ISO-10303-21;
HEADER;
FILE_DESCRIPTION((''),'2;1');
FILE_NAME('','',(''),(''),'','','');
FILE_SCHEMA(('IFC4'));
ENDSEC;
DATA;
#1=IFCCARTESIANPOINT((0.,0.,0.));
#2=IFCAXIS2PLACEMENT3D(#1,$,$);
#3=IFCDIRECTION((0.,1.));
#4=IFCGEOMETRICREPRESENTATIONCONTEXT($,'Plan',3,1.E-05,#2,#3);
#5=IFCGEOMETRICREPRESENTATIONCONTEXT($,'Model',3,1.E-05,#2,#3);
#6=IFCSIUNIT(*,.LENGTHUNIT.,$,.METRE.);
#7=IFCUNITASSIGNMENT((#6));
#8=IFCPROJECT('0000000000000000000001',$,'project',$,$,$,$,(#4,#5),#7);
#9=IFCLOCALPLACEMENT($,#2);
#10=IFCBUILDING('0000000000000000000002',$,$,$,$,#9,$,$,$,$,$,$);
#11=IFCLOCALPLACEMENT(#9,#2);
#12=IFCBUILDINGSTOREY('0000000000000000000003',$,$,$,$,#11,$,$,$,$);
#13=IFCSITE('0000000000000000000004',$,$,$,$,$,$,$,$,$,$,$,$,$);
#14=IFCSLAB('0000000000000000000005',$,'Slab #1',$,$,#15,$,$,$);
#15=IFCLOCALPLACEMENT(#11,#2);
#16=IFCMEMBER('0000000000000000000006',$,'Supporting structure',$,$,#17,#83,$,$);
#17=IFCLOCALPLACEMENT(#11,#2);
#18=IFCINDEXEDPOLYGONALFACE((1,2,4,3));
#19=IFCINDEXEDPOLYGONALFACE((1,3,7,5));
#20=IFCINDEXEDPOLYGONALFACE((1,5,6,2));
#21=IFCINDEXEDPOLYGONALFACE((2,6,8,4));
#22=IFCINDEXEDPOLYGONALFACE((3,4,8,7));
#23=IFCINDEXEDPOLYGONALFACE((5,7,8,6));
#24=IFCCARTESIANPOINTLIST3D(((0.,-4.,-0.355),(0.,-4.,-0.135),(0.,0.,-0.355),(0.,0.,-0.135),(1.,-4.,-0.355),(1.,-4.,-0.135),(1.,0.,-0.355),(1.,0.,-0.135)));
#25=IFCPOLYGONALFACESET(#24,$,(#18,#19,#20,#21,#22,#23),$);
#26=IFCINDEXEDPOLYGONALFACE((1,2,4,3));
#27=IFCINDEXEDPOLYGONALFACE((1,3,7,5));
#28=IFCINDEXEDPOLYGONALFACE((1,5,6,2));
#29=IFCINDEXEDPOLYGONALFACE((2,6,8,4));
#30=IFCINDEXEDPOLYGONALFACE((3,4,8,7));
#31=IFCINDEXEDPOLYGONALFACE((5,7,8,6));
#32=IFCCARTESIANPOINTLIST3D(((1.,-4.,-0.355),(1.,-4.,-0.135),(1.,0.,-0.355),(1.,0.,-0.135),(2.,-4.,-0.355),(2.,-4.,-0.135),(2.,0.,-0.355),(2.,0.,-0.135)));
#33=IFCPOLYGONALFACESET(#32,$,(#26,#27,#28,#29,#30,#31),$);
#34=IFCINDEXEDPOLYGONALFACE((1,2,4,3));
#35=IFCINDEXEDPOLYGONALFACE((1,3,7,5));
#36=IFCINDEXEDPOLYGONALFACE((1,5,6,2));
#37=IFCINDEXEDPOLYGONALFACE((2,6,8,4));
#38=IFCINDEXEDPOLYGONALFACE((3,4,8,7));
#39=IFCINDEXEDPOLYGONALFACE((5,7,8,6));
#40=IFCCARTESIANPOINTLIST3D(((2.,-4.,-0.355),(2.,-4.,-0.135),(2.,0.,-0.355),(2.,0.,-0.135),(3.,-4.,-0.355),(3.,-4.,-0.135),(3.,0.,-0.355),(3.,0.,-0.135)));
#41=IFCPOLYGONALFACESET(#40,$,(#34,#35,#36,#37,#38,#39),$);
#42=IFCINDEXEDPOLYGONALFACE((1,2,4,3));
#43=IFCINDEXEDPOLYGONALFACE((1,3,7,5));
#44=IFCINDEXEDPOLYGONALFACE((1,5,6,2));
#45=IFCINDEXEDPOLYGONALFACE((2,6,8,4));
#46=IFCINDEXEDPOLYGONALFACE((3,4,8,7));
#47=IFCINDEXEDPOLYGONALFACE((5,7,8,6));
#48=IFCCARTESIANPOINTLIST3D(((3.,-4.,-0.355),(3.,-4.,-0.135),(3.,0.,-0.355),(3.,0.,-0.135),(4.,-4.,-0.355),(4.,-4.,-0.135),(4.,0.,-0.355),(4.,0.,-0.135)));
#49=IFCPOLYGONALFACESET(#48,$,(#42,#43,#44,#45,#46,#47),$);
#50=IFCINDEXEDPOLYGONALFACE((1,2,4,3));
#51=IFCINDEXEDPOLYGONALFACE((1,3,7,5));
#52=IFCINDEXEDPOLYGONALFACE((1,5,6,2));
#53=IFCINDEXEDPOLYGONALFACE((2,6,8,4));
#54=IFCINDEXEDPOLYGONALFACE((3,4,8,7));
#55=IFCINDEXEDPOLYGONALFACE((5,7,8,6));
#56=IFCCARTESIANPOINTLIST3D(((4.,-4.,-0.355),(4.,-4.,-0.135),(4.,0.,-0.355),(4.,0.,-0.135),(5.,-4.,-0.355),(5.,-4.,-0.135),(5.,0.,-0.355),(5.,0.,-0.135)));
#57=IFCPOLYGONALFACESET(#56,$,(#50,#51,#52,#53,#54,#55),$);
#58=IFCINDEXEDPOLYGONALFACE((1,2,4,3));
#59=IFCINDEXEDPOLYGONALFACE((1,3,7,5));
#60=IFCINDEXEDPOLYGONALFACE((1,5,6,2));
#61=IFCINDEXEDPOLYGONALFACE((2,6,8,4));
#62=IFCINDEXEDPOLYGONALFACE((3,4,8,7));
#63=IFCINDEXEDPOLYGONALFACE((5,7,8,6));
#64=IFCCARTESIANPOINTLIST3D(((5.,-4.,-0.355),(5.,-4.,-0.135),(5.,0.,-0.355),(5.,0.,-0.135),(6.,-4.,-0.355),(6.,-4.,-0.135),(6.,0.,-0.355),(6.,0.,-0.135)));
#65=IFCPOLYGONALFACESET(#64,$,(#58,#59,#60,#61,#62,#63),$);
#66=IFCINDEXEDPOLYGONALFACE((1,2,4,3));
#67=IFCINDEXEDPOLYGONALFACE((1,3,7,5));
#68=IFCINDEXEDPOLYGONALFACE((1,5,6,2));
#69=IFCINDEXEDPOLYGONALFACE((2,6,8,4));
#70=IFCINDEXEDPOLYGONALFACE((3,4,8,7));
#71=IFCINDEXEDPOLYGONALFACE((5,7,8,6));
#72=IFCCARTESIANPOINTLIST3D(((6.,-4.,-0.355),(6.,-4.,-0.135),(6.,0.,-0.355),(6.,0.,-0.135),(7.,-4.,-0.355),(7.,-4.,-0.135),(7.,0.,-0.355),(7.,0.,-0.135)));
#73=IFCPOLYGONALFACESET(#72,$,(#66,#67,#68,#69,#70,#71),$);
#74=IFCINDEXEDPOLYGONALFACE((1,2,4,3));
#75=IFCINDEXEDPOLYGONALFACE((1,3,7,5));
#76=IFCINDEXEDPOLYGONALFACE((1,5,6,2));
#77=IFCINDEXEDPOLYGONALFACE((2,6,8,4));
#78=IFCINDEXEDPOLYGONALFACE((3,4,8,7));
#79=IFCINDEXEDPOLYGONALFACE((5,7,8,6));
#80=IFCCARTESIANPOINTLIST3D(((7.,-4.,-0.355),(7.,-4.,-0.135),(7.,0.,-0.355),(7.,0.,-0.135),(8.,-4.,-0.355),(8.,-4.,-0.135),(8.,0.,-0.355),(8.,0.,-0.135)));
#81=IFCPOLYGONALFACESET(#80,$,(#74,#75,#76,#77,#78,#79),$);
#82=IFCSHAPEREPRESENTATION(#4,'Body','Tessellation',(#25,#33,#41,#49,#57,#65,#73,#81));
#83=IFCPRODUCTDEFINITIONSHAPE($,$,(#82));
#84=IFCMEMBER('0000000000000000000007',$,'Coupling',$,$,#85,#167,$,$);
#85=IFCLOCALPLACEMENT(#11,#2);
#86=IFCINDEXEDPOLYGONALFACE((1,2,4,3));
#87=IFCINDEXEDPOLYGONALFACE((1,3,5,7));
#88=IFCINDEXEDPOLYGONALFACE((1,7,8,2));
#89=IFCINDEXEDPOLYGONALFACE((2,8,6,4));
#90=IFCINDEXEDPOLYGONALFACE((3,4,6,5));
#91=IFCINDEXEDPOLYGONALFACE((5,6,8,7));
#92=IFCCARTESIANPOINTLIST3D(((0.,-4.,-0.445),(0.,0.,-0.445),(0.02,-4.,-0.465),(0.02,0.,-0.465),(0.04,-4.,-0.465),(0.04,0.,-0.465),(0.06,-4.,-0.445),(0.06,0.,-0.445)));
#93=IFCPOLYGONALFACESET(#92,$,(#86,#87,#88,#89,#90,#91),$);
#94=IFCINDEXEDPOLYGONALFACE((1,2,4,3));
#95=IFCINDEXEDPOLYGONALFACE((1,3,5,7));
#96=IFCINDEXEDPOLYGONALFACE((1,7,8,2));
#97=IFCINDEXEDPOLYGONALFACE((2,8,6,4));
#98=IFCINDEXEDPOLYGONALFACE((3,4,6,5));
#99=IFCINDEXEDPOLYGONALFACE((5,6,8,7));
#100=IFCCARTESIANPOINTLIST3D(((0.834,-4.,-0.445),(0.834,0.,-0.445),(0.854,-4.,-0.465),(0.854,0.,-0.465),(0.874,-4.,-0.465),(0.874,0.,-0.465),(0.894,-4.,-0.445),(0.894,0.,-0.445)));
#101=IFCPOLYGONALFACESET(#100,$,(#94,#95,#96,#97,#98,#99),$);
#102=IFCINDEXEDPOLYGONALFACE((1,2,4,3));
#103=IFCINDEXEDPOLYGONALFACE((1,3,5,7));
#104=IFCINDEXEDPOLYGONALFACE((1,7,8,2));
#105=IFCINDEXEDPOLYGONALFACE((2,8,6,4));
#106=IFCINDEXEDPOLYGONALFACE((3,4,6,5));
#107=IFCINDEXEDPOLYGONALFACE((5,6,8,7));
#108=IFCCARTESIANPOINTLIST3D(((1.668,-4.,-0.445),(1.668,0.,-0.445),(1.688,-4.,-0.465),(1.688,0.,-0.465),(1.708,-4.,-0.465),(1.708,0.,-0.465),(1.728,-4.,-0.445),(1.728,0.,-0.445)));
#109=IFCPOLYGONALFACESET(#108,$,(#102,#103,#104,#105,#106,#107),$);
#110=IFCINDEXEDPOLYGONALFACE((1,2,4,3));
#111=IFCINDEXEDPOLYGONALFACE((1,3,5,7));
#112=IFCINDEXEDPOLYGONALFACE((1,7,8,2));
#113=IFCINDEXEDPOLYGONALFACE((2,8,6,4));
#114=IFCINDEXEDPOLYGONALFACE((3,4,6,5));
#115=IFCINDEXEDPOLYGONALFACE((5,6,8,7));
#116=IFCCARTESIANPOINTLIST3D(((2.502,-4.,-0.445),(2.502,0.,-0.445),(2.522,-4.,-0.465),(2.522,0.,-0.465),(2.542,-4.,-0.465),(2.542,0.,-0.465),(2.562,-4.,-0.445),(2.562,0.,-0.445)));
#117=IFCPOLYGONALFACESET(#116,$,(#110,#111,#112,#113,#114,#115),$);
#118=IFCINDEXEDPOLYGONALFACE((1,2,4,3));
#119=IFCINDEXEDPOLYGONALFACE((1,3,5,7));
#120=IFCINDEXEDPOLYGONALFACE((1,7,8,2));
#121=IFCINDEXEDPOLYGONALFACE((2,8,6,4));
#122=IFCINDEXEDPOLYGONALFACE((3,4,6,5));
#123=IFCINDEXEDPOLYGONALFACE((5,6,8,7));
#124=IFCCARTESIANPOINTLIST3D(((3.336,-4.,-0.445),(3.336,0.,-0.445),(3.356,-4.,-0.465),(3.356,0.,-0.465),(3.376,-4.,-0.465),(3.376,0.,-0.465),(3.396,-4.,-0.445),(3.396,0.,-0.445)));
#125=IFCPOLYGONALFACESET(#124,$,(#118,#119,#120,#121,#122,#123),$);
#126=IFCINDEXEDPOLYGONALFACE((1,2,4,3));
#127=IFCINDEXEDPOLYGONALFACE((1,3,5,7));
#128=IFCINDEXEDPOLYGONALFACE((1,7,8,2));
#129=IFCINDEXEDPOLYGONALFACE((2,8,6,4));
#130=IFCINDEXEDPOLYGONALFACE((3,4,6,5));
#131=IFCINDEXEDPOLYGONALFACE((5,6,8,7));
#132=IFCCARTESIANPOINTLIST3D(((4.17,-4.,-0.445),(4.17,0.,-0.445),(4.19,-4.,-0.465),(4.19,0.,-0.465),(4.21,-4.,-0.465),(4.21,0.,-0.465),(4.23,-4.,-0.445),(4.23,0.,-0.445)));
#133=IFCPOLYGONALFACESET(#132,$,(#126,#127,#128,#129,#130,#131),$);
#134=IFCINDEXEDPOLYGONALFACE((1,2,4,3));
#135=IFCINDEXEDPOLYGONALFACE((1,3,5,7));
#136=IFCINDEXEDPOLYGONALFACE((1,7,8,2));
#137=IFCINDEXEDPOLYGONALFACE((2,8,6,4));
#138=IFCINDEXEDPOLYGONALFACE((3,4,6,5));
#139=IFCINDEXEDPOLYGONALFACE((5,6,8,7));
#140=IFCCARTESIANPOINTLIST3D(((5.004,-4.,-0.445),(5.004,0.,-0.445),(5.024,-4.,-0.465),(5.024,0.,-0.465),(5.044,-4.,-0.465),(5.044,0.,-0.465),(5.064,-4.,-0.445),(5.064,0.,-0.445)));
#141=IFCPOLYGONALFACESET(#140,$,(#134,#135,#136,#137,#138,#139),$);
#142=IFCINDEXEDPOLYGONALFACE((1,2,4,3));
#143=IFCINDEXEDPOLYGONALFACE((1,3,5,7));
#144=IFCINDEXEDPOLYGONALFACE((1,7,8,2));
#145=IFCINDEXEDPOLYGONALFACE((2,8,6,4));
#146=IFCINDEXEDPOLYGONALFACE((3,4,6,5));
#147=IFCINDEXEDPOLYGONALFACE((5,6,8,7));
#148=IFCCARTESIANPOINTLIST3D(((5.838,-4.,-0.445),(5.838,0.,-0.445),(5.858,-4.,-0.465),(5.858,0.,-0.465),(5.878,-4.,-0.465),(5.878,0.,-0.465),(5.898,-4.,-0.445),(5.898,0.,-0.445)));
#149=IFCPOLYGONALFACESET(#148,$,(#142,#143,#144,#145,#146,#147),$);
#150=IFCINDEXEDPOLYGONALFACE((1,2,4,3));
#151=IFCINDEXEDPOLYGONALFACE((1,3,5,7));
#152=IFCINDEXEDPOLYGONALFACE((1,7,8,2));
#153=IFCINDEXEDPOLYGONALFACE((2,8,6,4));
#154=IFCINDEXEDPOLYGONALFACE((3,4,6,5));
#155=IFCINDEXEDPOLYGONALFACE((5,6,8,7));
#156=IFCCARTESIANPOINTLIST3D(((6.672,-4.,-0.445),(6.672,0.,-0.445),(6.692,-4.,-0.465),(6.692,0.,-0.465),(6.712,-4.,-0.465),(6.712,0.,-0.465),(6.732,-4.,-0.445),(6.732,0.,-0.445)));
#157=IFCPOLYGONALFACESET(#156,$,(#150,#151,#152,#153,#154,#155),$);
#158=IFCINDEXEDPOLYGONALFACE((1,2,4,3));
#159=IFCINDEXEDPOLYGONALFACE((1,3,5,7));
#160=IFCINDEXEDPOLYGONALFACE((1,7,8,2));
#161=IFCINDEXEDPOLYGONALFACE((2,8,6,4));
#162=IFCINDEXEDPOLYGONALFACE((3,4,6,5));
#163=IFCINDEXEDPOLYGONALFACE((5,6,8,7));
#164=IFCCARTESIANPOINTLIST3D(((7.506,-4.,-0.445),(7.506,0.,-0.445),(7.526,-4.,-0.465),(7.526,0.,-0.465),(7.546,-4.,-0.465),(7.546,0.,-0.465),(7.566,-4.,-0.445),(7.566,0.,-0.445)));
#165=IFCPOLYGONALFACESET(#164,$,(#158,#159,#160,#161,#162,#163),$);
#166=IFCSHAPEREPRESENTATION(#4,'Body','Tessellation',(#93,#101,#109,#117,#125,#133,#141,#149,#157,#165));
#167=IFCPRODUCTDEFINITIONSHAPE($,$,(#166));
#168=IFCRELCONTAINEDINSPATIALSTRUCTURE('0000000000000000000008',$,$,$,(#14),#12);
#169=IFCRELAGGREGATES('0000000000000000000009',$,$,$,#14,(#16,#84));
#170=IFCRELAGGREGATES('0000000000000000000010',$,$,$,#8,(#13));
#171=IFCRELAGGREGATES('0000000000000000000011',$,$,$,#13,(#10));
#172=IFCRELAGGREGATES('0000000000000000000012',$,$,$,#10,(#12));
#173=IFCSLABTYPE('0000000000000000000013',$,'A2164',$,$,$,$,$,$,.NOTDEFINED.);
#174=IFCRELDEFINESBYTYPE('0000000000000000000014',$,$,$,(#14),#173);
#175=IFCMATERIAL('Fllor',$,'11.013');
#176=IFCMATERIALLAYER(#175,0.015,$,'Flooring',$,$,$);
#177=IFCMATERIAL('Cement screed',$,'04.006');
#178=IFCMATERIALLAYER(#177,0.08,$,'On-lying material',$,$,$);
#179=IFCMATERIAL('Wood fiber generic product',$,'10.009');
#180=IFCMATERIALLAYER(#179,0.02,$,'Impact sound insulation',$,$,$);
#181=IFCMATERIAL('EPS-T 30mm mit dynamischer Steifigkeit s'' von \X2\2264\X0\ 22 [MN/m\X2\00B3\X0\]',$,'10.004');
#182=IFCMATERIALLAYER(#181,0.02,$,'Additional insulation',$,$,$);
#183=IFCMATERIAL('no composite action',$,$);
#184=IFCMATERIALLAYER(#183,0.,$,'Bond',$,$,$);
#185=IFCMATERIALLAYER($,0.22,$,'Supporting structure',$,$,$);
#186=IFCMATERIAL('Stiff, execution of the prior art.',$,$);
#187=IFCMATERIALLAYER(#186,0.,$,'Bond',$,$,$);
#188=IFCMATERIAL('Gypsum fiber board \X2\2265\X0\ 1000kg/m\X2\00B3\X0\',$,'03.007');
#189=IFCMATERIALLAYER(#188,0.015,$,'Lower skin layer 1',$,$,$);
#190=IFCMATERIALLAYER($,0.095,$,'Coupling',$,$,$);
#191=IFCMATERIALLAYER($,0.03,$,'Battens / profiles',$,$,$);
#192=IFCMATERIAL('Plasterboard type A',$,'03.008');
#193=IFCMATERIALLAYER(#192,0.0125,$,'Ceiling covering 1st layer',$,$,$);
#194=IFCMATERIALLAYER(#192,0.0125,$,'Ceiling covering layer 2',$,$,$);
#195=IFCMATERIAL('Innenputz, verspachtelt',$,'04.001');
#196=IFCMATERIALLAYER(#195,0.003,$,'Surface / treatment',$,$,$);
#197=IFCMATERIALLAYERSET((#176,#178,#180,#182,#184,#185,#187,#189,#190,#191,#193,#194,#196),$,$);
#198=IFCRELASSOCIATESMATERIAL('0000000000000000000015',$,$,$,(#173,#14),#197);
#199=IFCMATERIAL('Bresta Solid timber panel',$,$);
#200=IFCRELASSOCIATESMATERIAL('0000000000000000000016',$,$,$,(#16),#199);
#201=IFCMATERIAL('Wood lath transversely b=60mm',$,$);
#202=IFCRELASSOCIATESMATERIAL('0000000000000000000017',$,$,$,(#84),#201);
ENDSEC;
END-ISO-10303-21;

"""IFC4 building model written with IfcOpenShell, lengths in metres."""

from ifc_helpers import new_model, si_unit, direction, frame, frame_2d, origin, place, context, project, spatial, polyline, rectangle, outline, extrude, material, layer, layer_set, type_object, element, aggregate, save


model = new_model("IFC4")

# Units and contexts
plan_context = context("Plan", 3, precision=1e-05, world=origin(), true_north=direction((0.0, 1.0)))
model_context = context("Model", 3, precision=1e-05, world=origin(), true_north=direction((0.0, 1.0)))
ifc_project = project(units=[si_unit("LENGTHUNIT", "METRE")], contexts=[plan_context, model_context])

# Site, building, storey
site = spatial("IfcSite", under=ifc_project)
building_placement = place(None, origin())
building = spatial("IfcBuilding", under=site, at=building_placement)
storey_placement = place(building_placement, origin())
storey = spatial("IfcBuildingStorey", under=building, at=storey_placement)

# Slab, members
ifc_material_1 = material(Name="Fllor", Category="11.013")
ifc_layer_1 = layer(ifc_material_1, 0.015, Name="Flooring")
ifc_material_2 = material(Name="Cement screed", Category="04.006")
ifc_layer_2 = layer(ifc_material_2, 0.08, Name="On-lying material")
ifc_material_3 = material(Name="Wood fiber generic product", Category="10.009")
ifc_layer_3 = layer(ifc_material_3, 0.02, Name="Impact sound insulation")
ifc_material_4 = material(Name="EPS-T 30mm mit dynamischer Steifigkeit s' von ≤ 22 [MN/m³]", Category="10.004")
ifc_layer_4 = layer(ifc_material_4, 0.02, Name="Additional insulation")
ifc_material_5 = material(Name="no composite action")
ifc_layer_5 = layer(ifc_material_5, 0.0, Name="Bond")
ifc_layer_6 = layer(None, 0.22, Name="Supporting structure")
ifc_material_6 = material(Name="Stiff, execution of the prior art.")
ifc_layer_7 = layer(ifc_material_6, 0.0, Name="Bond")
ifc_material_7 = material(Name="Gypsum fiber board ≥ 1000kg/m³", Category="03.007")
ifc_layer_8 = layer(ifc_material_7, 0.015, Name="Lower skin layer 1")
ifc_layer_9 = layer(None, 0.095, Name="Coupling")
ifc_layer_10 = layer(None, 0.03, Name="Battens / profiles")
ifc_material_8 = material(Name="Plasterboard type A", Category="03.008")
ifc_layer_11 = layer(ifc_material_8, 0.0125, Name="Ceiling covering 1st layer")
ifc_layer_12 = layer(ifc_material_8, 0.0125, Name="Ceiling covering layer 2")
ifc_material_9 = material(Name="Innenputz, verspachtelt", Category="04.001")
ifc_layer_13 = layer(ifc_material_9, 0.003, Name="Surface / treatment")
ifc_layer_set = layer_set([ifc_layer_1, ifc_layer_2, ifc_layer_3, ifc_layer_4, ifc_layer_5, ifc_layer_6, ifc_layer_7, ifc_layer_8, ifc_layer_9, ifc_layer_10, ifc_layer_11, ifc_layer_12, ifc_layer_13])
slab_type = type_object("IfcSlabType", Name="A2164", PredefinedType="NOTDEFINED", material=ifc_layer_set)
slab_placement = place(None, frame((0.0, 0.0, 0.0), z_axis=(0.0, 0.0, -1.0), x_axis=(1.0, 0.0, 0.0)))
slab = element("IfcSlab", 1, at=slab_placement, inside=storey, type_object=slab_type, material=ifc_layer_set, Name="Slab #1")
ifc_material_10 = material(Name="Bresta Solid timber panel")
member_1_placement = place(slab_placement, origin())
member_1 = element("IfcMember", 2, at=member_1_placement, material=ifc_material_10, Name="Supporting structure", context=plan_context, shape_type="SweptSolid", body=[
    extrude(rectangle(XDim=1.0, YDim=0.22, at=frame_2d((0.5, 0.11), x_axis=(1.0, 0.0))), frame((0.0, 4.0, 0.135), z_axis=(0.0, -1.0, 0.0), x_axis=(1.0, 0.0, 0.0)), (0.0, 0.0, 1.0), 4.0),
    extrude(rectangle(XDim=1.0, YDim=0.22, at=frame_2d((0.5, 0.11), x_axis=(1.0, 0.0))), frame((1.0, 4.0, 0.135), z_axis=(0.0, -1.0, 0.0), x_axis=(1.0, 0.0, 0.0)), (0.0, 0.0, 1.0), 4.0),
    extrude(rectangle(XDim=1.0, YDim=0.22, at=frame_2d((0.5, 0.11), x_axis=(1.0, 0.0))), frame((2.0, 4.0, 0.135), z_axis=(0.0, -1.0, 0.0), x_axis=(1.0, 0.0, 0.0)), (0.0, 0.0, 1.0), 4.0),
    extrude(rectangle(XDim=1.0, YDim=0.22, at=frame_2d((0.5, 0.11), x_axis=(1.0, 0.0))), frame((3.0, 4.0, 0.135), z_axis=(0.0, -1.0, 0.0), x_axis=(1.0, 0.0, 0.0)), (0.0, 0.0, 1.0), 4.0),
    extrude(rectangle(XDim=1.0, YDim=0.22, at=frame_2d((0.5, 0.11), x_axis=(1.0, 0.0))), frame((4.0, 4.0, 0.135), z_axis=(0.0, -1.0, 0.0), x_axis=(1.0, 0.0, 0.0)), (0.0, 0.0, 1.0), 4.0),
    extrude(rectangle(XDim=1.0, YDim=0.22, at=frame_2d((0.5, 0.11), x_axis=(1.0, 0.0))), frame((5.0, 4.0, 0.135), z_axis=(0.0, -1.0, 0.0), x_axis=(1.0, 0.0, 0.0)), (0.0, 0.0, 1.0), 4.0),
    extrude(rectangle(XDim=1.0, YDim=0.22, at=frame_2d((0.5, 0.11), x_axis=(1.0, 0.0))), frame((6.0, 4.0, 0.135), z_axis=(0.0, -1.0, 0.0), x_axis=(1.0, 0.0, 0.0)), (0.0, 0.0, 1.0), 4.0),
    extrude(rectangle(XDim=1.0, YDim=0.22, at=frame_2d((0.5, 0.11), x_axis=(1.0, 0.0))), frame((7.0, 4.0, 0.135), z_axis=(0.0, -1.0, 0.0), x_axis=(1.0, 0.0, 0.0)), (0.0, 0.0, 1.0), 4.0),
])
ifc_material_11 = material(Name="Wood lath transversely b=60mm")
member_2_placement = place(slab_placement, origin())
member_2 = element("IfcMember", 3, at=member_2_placement, material=ifc_material_11, Name="Coupling", context=plan_context, shape_type="SweptSolid", body=[
    extrude(outline(polyline([(0.0, 0.0), (0.06, 0.0), (0.04, 0.02), (0.02, 0.02), (0.0, 0.0)])), frame((0.0, 4.0, 0.445), z_axis=(0.0, -1.0, 0.0), x_axis=(1.0, 0.0, 0.0)), (0.0, 0.0, 1.0), 4.0),
    extrude(outline(polyline([(0.0, 0.0), (0.06, 0.0), (0.04, 0.02), (0.02, 0.02), (0.0, 0.0)])), frame((0.834, 4.0, 0.445), z_axis=(0.0, -1.0, 0.0), x_axis=(1.0, 0.0, 0.0)), (0.0, 0.0, 1.0), 4.0),
    extrude(outline(polyline([(0.0, 0.0), (0.06, 0.0), (0.04, 0.02), (0.02, 0.02), (0.0, 0.0)])), frame((1.668, 4.0, 0.445), z_axis=(0.0, -1.0, 0.0), x_axis=(1.0, 0.0, 0.0)), (0.0, 0.0, 1.0), 4.0),
    extrude(outline(polyline([(0.0, 0.0), (0.06, 0.0), (0.04, 0.02), (0.02, 0.02), (0.0, 0.0)])), frame((2.502, 4.0, 0.445), z_axis=(0.0, -1.0, 0.0), x_axis=(1.0, 0.0, 0.0)), (0.0, 0.0, 1.0), 4.0),
    extrude(outline(polyline([(0.0, 0.0), (0.06, 0.0), (0.04, 0.02), (0.02, 0.02), (0.0, 0.0)])), frame((3.336, 4.0, 0.445), z_axis=(0.0, -1.0, 0.0), x_axis=(1.0, 0.0, 0.0)), (0.0, 0.0, 1.0), 4.0),
    extrude(outline(polyline([(0.0, 0.0), (0.06, 0.0), (0.04, 0.02), (0.02, 0.02), (0.0, 0.0)])), frame((4.17, 4.0, 0.445), z_axis=(0.0, -1.0, 0.0), x_axis=(1.0, 0.0, 0.0)), (0.0, 0.0, 1.0), 4.0),
    extrude(outline(polyline([(0.0, 0.0), (0.06, 0.0), (0.04, 0.02), (0.02, 0.02), (0.0, 0.0)])), frame((5.004, 4.0, 0.445), z_axis=(0.0, -1.0, 0.0), x_axis=(1.0, 0.0, 0.0)), (0.0, 0.0, 1.0), 4.0),
    extrude(outline(polyline([(0.0, 0.0), (0.06, 0.0), (0.04, 0.02), (0.02, 0.02), (0.0, 0.0)])), frame((5.838, 4.0, 0.445), z_axis=(0.0, -1.0, 0.0), x_axis=(1.0, 0.0, 0.0)), (0.0, 0.0, 1.0), 4.0),
    extrude(outline(polyline([(0.0, 0.0), (0.06, 0.0), (0.04, 0.02), (0.02, 0.02), (0.0, 0.0)])), frame((6.672, 4.0, 0.445), z_axis=(0.0, -1.0, 0.0), x_axis=(1.0, 0.0, 0.0)), (0.0, 0.0, 1.0), 4.0),
    extrude(outline(polyline([(0.0, 0.0), (0.06, 0.0), (0.04, 0.02), (0.02, 0.02), (0.0, 0.0)])), frame((7.506, 4.0, 0.445), z_axis=(0.0, -1.0, 0.0), x_axis=(1.0, 0.0, 0.0)), (0.0, 0.0, 1.0), 4.0),
])
aggregate(slab, [member_1, member_2])

save(model, "model.ifc")
